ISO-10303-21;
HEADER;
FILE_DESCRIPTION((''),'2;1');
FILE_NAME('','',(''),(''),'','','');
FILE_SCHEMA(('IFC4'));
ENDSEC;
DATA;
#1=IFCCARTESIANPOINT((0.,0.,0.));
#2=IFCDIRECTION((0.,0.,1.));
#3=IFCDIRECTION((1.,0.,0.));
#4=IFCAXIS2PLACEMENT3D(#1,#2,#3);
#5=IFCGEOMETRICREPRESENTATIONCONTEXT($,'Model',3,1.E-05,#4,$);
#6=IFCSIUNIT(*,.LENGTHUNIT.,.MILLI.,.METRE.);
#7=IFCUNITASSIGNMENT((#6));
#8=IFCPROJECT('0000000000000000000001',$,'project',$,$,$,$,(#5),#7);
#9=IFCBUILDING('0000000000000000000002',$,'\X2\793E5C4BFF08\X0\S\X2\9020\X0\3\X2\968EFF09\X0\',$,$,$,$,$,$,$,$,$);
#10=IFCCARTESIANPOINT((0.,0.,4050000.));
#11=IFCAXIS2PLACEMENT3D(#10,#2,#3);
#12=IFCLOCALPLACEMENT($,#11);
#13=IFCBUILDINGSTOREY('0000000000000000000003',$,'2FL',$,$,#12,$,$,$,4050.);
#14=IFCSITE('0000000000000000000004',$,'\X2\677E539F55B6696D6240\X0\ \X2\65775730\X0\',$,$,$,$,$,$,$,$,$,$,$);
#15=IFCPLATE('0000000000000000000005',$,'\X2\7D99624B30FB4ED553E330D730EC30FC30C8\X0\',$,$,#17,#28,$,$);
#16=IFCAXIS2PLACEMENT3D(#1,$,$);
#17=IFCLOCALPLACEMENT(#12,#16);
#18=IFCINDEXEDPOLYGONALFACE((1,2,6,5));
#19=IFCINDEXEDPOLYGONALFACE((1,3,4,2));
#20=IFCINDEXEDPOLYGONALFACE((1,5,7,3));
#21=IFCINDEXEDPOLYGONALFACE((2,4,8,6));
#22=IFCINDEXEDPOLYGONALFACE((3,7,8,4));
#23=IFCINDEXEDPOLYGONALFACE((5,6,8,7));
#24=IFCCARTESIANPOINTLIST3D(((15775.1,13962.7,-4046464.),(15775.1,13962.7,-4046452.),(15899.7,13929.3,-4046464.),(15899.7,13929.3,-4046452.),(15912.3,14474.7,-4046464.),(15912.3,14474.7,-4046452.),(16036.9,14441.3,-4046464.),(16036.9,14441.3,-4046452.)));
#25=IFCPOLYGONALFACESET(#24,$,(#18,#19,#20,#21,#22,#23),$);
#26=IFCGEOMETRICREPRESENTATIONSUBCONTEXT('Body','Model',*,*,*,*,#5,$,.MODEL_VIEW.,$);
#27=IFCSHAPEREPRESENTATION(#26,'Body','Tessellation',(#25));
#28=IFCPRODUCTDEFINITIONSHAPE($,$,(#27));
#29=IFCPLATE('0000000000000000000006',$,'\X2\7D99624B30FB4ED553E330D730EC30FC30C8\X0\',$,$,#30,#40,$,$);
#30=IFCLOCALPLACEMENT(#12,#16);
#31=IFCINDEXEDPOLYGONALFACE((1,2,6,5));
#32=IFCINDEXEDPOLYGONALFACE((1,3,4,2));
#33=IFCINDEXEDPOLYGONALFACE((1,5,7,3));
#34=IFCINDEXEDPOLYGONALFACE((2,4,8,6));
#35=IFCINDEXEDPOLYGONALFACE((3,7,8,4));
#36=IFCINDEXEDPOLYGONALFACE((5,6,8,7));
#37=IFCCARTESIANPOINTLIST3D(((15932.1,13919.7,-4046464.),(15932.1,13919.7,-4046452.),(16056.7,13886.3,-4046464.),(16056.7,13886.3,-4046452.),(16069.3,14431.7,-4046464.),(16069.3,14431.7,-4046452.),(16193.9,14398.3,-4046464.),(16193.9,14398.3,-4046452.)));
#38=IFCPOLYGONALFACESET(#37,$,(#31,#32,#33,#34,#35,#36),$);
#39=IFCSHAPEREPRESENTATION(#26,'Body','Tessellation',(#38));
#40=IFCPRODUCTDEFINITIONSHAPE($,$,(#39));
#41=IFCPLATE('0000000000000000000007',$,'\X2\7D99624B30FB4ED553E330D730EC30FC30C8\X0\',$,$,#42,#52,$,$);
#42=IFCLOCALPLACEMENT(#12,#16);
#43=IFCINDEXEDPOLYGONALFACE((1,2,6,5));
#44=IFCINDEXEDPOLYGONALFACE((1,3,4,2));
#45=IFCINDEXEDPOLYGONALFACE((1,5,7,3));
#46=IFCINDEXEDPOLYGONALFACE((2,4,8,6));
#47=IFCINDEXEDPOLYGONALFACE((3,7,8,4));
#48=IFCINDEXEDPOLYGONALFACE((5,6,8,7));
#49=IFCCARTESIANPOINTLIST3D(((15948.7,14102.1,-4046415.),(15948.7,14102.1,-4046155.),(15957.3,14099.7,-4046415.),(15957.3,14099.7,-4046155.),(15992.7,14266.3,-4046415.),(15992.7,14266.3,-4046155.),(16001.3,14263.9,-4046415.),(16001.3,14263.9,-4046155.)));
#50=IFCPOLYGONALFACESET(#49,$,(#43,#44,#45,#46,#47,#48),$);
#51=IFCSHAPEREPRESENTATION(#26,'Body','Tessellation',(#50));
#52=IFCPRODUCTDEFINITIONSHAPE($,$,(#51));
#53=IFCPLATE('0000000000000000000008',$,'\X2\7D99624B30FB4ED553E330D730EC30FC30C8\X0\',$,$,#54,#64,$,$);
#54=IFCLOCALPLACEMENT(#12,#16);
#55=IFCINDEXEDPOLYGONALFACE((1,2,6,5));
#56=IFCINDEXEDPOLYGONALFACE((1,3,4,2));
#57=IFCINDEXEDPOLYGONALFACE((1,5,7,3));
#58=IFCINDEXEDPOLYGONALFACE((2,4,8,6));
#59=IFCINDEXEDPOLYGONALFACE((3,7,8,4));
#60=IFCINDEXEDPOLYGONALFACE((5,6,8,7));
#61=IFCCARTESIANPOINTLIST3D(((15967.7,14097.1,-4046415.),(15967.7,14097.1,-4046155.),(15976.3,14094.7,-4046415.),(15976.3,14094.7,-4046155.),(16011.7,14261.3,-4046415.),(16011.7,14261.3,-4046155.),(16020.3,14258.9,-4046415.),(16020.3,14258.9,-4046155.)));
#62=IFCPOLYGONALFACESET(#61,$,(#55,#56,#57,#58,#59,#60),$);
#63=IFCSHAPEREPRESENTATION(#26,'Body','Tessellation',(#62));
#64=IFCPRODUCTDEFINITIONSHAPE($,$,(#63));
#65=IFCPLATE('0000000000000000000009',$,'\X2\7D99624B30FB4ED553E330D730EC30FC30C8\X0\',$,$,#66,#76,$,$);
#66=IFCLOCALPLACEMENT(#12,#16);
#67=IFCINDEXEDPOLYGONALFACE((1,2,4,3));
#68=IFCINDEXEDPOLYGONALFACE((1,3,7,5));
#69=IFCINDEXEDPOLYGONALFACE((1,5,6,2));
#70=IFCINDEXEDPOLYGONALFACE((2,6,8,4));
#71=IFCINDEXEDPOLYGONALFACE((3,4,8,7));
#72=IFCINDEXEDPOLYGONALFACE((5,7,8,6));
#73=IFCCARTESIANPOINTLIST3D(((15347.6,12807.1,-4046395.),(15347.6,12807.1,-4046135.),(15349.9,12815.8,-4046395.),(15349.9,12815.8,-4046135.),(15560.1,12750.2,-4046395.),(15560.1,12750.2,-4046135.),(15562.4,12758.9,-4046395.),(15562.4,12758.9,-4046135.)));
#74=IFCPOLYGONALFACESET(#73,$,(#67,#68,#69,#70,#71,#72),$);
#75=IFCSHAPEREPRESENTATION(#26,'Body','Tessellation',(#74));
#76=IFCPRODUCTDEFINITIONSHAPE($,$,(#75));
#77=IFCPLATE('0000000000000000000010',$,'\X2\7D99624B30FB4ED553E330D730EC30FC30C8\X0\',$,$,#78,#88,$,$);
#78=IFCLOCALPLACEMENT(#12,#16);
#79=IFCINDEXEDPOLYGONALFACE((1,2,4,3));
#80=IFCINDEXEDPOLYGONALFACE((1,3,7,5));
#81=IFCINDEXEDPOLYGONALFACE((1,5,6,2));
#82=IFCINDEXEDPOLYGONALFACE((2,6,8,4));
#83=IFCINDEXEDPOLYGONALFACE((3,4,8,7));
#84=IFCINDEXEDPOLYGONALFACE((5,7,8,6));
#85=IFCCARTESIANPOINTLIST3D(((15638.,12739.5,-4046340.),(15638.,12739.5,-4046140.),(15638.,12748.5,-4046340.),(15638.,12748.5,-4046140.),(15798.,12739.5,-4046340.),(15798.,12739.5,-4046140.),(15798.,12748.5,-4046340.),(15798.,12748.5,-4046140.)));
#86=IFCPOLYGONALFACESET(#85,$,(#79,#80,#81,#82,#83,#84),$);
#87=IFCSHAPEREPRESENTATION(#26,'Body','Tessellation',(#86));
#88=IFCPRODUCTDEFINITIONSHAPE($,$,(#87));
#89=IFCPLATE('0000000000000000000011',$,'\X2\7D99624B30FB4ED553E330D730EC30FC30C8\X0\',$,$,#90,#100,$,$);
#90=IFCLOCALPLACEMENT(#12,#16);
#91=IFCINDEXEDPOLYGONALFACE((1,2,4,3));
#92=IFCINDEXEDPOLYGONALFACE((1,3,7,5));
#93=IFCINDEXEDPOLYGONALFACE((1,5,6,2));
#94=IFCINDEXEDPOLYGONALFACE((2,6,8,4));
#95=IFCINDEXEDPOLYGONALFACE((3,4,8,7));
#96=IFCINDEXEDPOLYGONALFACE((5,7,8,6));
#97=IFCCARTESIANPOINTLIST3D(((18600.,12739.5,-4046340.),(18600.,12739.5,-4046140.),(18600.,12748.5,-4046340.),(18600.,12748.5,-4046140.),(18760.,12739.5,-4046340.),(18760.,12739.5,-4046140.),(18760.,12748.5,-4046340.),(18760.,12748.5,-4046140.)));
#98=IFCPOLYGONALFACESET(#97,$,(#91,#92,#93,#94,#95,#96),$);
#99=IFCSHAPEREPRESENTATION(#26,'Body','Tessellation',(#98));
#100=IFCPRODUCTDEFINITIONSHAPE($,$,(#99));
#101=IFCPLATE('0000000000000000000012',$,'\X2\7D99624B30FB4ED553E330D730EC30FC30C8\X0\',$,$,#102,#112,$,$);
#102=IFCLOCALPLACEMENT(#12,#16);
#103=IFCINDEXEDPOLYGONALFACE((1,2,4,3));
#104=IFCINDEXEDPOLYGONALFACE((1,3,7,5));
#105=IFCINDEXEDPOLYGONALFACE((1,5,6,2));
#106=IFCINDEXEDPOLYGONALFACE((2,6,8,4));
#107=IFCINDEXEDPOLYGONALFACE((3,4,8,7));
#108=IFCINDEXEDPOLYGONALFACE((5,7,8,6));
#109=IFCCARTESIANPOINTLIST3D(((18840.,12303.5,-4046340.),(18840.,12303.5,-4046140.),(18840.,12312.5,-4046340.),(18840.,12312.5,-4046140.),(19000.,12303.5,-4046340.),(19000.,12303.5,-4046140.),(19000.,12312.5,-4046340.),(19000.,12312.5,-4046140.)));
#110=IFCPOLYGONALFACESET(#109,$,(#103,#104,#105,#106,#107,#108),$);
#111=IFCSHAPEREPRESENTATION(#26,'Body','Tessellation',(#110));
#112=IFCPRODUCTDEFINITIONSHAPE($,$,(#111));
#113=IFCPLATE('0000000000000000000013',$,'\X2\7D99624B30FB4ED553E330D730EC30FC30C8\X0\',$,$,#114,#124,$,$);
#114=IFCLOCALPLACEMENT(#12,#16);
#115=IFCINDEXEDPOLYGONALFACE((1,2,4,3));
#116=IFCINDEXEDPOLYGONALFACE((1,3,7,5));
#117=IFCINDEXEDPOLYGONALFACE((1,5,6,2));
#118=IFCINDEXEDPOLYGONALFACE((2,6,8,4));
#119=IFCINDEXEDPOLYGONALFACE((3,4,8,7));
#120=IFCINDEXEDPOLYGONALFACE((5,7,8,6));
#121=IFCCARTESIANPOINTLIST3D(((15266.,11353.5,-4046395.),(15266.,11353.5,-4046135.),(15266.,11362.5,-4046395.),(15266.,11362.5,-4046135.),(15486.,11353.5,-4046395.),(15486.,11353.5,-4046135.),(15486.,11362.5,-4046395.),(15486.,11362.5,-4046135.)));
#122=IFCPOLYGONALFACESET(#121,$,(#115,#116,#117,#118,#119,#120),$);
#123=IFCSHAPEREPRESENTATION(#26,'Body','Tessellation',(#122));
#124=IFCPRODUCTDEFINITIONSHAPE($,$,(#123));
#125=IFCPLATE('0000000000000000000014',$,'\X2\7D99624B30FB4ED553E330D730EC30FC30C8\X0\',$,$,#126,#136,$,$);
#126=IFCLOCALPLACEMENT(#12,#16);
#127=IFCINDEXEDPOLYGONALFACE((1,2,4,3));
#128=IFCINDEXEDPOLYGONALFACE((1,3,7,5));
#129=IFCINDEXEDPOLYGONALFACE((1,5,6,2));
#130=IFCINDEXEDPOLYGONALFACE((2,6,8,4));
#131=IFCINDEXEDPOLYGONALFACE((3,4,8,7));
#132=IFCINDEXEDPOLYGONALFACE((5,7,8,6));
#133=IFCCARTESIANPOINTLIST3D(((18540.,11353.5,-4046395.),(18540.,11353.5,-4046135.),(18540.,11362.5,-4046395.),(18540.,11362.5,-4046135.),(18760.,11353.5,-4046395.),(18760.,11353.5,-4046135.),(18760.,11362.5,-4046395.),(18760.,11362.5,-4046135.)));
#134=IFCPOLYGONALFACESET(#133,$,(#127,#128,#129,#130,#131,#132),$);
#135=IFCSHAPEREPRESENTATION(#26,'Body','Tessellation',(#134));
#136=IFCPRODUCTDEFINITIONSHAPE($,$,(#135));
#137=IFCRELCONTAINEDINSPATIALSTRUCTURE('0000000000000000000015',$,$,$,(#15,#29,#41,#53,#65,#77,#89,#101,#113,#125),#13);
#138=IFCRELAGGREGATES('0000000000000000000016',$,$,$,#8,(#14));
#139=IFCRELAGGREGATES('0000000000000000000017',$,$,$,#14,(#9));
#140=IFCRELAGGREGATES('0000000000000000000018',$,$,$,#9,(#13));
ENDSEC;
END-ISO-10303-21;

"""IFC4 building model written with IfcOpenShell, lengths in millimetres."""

from ifc_helpers import new_model, si_unit, frame, origin, origin_with_axes, place, context, subcontext, project, spatial, rectangle, extrude, element, save


model = new_model("IFC4")

# Units and contexts
model_context = context("Model", 3, precision=1e-05, world=origin_with_axes())
body_context = subcontext(model_context, "Body", "Model", "MODEL_VIEW")
ifc_project = project(units=[si_unit("LENGTHUNIT", "METRE", prefix="MILLI")], contexts=[model_context])

# Site, building, storey
site = spatial("IfcSite", under=ifc_project, Name="松原営業所 敷地")
building = spatial("IfcBuilding", under=site, Name="社屋（S造3階）")
storey_placement = place(None, frame((0.0, 0.0, 4050000.0), z_axis=(0.0, 0.0, 1.0), x_axis=(1.0, 0.0, 0.0)))
storey = spatial("IfcBuildingStorey", under=building, at=storey_placement, Name="2FL", Elevation=4050.0)

# Plates
for number, where, z_axis, x_axis, name in (
    (1, (15837.4, 13946.0, -4046458.0), (0.258819, 0.965926, 0.0), (-0.965926, 0.258819, 0.0), "継手・仕口プレート"),
    (2, (15994.4, 13903.0, -4046458.0), (0.258819, 0.965926, 0.0), (-0.965926, 0.258819, 0.0), "継手・仕口プレート"),
):
    element("IfcPlate", number, at=place(storey_placement, frame(where, z_axis=z_axis, x_axis=x_axis)), inside=storey, Name=name, context=body_context, shape_type="SweptSolid", body=[
        extrude(rectangle(XDim=129.0, YDim=12.0), origin(), (0.0, 0.0, 1.0), 530.0),
    ])
for number, where, z_axis, x_axis, name in (
    (3, (15953.0, 14100.9, -4046285.0), (0.258819, 0.965926, 0.0), (-0.965926, 0.258819, 0.0), "継手・仕口プレート"),
    (4, (15972.0, 14095.9, -4046285.0), (0.258819, 0.965926, 0.0), (-0.965926, 0.258819, 0.0), "継手・仕口プレート"),
):
    element("IfcPlate", number, at=place(storey_placement, frame(where, z_axis=z_axis, x_axis=x_axis)), inside=storey, Name=name, context=body_context, shape_type="SweptSolid", body=[
        extrude(rectangle(XDim=9.0, YDim=260.0), origin(), (0.0, 0.0, 1.0), 170.0),
    ])
plate_1_placement = place(storey_placement, frame((15348.7, 12811.5, -4046265.0), z_axis=(0.965926, -0.258819, 0.0), x_axis=(0.258819, 0.965926, 0.0)))
element("IfcPlate", 5, at=plate_1_placement, inside=storey, Name="継手・仕口プレート", context=body_context, shape_type="SweptSolid", body=[
    extrude(rectangle(XDim=9.0, YDim=260.0), origin(), (0.0, 0.0, 1.0), 220.0),
])
for number, where, z_axis, x_axis, name in (
    (6, (15638.0, 12744.0, -4046240.0), (1.0, 0.0, 0.0), (0.0, 1.0, 0.0), "継手・仕口プレート"),
    (7, (18600.0, 12744.0, -4046240.0), (1.0, 0.0, 0.0), (0.0, 1.0, 0.0), "継手・仕口プレート"),
    (8, (18840.0, 12308.0, -4046240.0), (1.0, 0.0, 0.0), (0.0, 1.0, 0.0), "継手・仕口プレート"),
):
    element("IfcPlate", number, at=place(storey_placement, frame(where, z_axis=z_axis, x_axis=x_axis)), inside=storey, Name=name, context=body_context, shape_type="SweptSolid", body=[
        extrude(rectangle(XDim=9.0, YDim=200.0), origin(), (0.0, 0.0, 1.0), 160.0),
    ])
for number, where, z_axis, x_axis, name in (
    (9, (15266.0, 11358.0, -4046265.0), (1.0, 0.0, 0.0), (0.0, 1.0, 0.0), "継手・仕口プレート"),
    (10, (18540.0, 11358.0, -4046265.0), (1.0, 0.0, 0.0), (0.0, 1.0, 0.0), "継手・仕口プレート"),
):
    element("IfcPlate", number, at=place(storey_placement, frame(where, z_axis=z_axis, x_axis=x_axis)), inside=storey, Name=name, context=body_context, shape_type="SweptSolid", body=[
        extrude(rectangle(XDim=9.0, YDim=260.0), origin(), (0.0, 0.0, 1.0), 220.0),
    ])

save(model, "model.ifc")
